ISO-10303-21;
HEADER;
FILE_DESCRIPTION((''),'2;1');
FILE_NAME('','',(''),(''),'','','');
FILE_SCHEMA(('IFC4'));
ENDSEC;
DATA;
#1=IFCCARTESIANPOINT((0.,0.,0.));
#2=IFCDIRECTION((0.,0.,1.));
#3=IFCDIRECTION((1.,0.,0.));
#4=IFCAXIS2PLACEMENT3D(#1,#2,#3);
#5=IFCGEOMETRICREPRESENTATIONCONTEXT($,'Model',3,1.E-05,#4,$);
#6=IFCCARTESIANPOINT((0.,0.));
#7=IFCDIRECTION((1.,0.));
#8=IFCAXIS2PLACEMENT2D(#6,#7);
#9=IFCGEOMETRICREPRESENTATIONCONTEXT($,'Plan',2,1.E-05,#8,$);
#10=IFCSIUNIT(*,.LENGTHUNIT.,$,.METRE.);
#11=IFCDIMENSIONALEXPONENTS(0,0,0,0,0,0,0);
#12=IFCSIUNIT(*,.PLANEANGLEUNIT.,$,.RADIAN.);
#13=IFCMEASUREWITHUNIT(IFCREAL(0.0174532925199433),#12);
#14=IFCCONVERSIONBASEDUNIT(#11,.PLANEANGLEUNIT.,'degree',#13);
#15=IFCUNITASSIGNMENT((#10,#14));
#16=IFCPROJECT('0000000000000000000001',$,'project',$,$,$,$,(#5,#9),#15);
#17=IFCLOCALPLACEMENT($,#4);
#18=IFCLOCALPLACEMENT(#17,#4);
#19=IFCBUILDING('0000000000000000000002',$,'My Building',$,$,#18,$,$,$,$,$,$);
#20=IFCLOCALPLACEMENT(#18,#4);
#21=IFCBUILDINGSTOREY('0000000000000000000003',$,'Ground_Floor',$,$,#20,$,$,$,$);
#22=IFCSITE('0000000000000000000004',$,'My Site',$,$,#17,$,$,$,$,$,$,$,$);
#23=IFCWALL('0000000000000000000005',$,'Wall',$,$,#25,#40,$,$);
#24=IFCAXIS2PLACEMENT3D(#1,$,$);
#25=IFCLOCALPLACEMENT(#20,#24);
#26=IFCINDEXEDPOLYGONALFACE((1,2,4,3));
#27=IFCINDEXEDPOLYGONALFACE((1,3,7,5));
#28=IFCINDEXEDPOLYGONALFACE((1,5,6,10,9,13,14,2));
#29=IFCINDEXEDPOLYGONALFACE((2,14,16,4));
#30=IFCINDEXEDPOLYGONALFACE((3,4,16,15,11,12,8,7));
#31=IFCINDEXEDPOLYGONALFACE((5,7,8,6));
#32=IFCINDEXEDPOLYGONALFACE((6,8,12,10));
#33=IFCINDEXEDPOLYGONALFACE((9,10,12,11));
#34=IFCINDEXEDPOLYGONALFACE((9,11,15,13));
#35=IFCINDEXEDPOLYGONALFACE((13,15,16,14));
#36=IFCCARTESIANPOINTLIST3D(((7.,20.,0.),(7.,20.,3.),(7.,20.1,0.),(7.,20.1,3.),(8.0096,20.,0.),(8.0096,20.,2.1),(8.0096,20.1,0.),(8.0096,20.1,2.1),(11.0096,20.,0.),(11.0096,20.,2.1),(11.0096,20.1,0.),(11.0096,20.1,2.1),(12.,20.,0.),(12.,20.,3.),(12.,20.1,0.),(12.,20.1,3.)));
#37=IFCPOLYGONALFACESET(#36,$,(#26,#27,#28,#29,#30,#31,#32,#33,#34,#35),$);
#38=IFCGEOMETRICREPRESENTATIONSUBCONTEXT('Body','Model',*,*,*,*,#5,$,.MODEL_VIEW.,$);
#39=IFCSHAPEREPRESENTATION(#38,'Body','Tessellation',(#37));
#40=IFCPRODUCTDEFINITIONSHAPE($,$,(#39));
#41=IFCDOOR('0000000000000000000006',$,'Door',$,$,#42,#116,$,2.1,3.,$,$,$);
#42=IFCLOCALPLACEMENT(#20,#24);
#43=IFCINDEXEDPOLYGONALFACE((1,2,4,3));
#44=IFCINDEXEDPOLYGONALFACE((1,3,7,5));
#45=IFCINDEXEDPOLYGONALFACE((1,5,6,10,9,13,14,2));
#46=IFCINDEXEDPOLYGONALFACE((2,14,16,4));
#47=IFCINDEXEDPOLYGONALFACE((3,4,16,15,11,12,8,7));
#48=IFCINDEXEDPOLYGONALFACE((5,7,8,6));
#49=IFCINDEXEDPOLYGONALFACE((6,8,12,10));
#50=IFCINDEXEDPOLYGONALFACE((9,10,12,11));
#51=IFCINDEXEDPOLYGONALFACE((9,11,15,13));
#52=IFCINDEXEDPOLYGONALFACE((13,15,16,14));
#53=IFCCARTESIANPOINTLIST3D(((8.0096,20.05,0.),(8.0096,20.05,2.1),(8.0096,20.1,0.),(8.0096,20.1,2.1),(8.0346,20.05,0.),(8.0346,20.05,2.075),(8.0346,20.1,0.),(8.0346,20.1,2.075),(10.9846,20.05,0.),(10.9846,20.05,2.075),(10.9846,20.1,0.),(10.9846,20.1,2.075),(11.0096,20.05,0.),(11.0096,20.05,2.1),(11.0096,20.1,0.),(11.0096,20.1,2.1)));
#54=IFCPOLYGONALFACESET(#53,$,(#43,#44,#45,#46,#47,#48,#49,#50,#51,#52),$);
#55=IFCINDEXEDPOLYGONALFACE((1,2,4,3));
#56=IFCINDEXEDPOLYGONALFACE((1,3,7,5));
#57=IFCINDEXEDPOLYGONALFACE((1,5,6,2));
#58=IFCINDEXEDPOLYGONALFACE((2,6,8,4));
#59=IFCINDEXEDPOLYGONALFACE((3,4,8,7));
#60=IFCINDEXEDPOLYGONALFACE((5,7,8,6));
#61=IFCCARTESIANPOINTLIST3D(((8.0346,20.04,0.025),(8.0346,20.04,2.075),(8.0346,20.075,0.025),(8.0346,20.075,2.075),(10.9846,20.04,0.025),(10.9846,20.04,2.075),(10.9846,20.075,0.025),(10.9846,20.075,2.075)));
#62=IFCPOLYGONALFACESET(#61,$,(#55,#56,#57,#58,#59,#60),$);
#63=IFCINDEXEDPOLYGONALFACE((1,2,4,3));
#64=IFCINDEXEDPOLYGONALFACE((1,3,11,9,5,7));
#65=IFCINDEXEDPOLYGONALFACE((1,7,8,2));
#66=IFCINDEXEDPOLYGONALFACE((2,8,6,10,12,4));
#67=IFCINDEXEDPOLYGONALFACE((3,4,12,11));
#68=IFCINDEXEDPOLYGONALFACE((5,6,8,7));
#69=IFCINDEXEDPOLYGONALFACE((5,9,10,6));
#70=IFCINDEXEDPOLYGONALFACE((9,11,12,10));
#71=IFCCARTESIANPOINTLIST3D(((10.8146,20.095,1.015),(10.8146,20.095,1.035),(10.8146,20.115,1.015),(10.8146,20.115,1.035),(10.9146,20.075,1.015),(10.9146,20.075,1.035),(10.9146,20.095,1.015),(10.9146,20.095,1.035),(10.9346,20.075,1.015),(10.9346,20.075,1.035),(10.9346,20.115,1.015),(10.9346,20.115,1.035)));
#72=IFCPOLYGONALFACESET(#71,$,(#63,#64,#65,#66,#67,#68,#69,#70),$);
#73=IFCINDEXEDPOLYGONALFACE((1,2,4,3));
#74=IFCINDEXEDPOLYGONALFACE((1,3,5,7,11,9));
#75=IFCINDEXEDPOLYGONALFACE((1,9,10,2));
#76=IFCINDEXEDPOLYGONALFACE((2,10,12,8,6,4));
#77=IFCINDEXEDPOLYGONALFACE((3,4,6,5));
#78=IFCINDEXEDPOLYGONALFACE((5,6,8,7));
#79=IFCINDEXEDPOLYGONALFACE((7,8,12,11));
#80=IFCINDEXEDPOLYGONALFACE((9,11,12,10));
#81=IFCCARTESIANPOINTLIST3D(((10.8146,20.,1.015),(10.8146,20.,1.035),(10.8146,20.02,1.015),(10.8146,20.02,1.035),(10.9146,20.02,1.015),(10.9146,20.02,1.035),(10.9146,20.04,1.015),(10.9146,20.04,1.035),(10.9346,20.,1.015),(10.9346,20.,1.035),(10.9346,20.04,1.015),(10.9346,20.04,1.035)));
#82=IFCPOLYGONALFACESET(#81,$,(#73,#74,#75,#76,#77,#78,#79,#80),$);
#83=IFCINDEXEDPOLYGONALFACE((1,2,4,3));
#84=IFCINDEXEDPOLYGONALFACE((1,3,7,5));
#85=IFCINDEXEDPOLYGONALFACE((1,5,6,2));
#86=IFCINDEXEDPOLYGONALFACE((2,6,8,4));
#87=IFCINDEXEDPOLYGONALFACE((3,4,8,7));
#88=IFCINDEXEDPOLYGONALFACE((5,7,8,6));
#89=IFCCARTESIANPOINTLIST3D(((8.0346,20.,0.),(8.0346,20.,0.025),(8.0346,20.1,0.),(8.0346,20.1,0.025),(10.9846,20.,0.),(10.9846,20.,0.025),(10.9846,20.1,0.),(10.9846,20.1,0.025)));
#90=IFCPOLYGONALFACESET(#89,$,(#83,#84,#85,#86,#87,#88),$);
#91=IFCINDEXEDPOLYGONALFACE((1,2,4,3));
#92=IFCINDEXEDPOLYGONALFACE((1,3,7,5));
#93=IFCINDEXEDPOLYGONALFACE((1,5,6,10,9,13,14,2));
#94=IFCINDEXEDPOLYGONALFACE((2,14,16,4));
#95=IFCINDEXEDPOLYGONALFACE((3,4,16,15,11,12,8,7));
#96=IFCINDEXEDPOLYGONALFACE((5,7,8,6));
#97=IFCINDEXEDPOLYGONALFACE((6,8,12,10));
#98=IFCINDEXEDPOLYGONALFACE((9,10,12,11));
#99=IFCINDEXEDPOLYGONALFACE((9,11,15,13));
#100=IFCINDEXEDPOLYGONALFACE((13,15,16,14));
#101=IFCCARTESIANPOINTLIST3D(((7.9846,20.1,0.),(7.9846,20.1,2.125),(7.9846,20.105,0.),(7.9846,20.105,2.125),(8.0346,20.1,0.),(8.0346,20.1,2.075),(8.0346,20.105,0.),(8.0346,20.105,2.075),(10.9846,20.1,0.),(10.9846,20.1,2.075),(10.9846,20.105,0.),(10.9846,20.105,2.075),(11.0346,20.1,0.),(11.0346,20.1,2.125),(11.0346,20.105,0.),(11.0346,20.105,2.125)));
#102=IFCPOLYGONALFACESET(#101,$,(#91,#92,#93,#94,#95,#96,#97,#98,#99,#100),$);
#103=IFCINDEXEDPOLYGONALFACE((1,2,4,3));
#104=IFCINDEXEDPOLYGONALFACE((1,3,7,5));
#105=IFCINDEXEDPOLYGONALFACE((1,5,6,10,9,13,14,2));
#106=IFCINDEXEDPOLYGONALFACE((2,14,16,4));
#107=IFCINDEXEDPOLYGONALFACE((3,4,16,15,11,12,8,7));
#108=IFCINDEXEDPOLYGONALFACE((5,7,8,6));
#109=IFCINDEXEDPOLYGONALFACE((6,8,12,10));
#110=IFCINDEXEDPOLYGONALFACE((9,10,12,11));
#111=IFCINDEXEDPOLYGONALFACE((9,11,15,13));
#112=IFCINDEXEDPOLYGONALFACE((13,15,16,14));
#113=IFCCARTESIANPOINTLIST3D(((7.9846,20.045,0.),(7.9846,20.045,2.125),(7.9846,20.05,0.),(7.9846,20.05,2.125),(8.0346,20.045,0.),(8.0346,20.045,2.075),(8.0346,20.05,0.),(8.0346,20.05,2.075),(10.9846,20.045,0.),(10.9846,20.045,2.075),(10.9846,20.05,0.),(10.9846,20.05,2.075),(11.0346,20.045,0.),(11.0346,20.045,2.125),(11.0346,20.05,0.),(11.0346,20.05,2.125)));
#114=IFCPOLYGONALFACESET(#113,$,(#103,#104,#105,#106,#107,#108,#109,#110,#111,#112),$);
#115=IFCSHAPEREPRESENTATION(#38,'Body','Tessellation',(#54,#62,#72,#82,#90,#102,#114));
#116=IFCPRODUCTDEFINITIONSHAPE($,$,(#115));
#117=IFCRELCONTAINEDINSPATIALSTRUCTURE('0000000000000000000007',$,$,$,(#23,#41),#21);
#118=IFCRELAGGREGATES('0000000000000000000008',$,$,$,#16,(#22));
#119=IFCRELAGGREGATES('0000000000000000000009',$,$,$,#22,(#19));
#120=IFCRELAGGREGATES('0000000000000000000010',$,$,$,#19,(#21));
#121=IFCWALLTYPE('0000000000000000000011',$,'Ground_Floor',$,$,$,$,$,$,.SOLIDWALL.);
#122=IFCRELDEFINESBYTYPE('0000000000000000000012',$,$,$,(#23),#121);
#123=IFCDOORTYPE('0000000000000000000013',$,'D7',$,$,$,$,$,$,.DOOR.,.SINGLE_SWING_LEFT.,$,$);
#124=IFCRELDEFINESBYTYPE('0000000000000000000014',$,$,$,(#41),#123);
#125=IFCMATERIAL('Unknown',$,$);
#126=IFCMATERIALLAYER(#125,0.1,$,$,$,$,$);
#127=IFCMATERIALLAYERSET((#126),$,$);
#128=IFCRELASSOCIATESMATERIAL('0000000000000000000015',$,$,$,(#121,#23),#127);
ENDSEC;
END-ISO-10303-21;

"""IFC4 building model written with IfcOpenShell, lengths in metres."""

from ifc_helpers import new_model, entity, si_unit, converted_unit, frame, origin_with_axes, origin_2d_with_axis, place, context, subcontext, project, spatial, line, indexed_curve, outline, extrude, shape, source, transform, mapped, material, layer, layer_set, layer_usage, type_object, type_shapes, element, fill, save


model = new_model("IFC4")

# Units and contexts
model_context = context("Model", 3, precision=1e-05, world=origin_with_axes())
plan_context = context("Plan", 2, precision=1e-05, world=origin_2d_with_axis())
body_context_1 = subcontext(model_context, "Body", "Model", "MODEL_VIEW")
body_context_2 = subcontext(plan_context, "Body", "Plan", "PLAN_VIEW")
ifc_project = project(units=[si_unit("LENGTHUNIT", "METRE"), converted_unit("PLANEANGLEUNIT", "degree", entity("IfcReal", 0.0174532925199433), si_unit("PLANEANGLEUNIT", "RADIAN"), dimensions=[0, 0, 0, 0, 0, 0, 0])], contexts=[model_context, plan_context])

# Site, building, storey
site_placement = place(None, origin_with_axes())
site = spatial("IfcSite", under=ifc_project, at=site_placement, Name="My Site")
building_placement = place(site_placement, origin_with_axes())
building = spatial("IfcBuilding", under=site, at=building_placement, Name="My Building")
storey_placement = place(building_placement, origin_with_axes())
storey = spatial("IfcBuildingStorey", under=building, at=storey_placement, Name="Ground_Floor")

# Shared definitions
ifc_material = material(Name="Unknown")

# Shared definitions
ifc_layer_1 = layer(ifc_material, 0.1)
ifc_layer_set_1 = layer_set([ifc_layer_1])
wall_type = type_object("IfcWallType", Name="Ground_Floor", PredefinedType="SOLIDWALL", material=ifc_layer_set_1)

# Wall, opening, door
ifc_layer_usage_1 = layer_usage(ifc_layer_set_1, "AXIS2", "POSITIVE", 0.0)
wall_1_placement = place(storey_placement, frame((7.0, 20.0, 0.0), z_axis=(0.0, 0.0, 1.0), x_axis=(1.0, 0.0, 0.0)))
wall_1 = element("IfcWall", 1, at=wall_1_placement, inside=storey, type_object=wall_type, material=ifc_layer_usage_1, Name="Wall", context=body_context_1, shape_type="SweptSolid", body=[
    extrude(outline(indexed_curve([(0.0, 0.0), (0.0, 0.1), (5.0, 0.1), (5.0, 0.0)], segments=[line(1, 2, 3, 4, 1)])), origin_with_axes(), (0.0, 0.0, 1.0), 3.0),
])
shared_shape_1 = source(origin_with_axes(), body_context_1, "Body", "SweptSolid", [
    extrude(outline(indexed_curve([(0.0, 0.0), (3.0, 0.0), (3.0, 2.1), (0.0, 2.1)], segments=[line(1, 2, 3, 4, 1)])), frame((0.0, -0.6, 0.0), z_axis=(0.0, -1.0, 0.0), x_axis=(1.0, 0.0, 0.0)), (0.0, 0.0, -1.0), 1.2),
])
opening_1_placement = place(wall_1_placement, frame((4.0096, 0.1, 0.0), z_axis=(0.0, 0.0, 1.0), x_axis=(-1.0, 0.0, 0.0)))
opening_1 = element("IfcOpeningElement", 2, at=opening_1_placement, cuts=wall_1, PredefinedType="OPENING", context=body_context_1, shape_type="MappedRepresentation", body=[
    mapped(shared_shape_1, transform((0.0, 0.0, 0.0), x_axis=(1.0, 0.0, 0.0), y_axis=(0.0, 1.0, 0.0), z_axis=(0.0, 0.0, 1.0), scale=1.0)),
])
door_type_1 = type_object("IfcDoorType", Name="D7", OperationType="SINGLE_SWING_LEFT", PredefinedType="DOOR")
shared_shape_2 = source(origin_with_axes(), body_context_1, "Body", "SweptSolid", [
    extrude(outline(indexed_curve([(0.0, 0.0), (0.0, 2.1), (3.0, 2.1), (3.0, 0.0), (2.975, 0.0), (2.975, 2.075), (0.025, 2.075), (0.025, 0.0)], segments=[line(1, 2, 3, 4, 5, 6, 7, 8, 1)])), frame((0.0, 0.0, 0.0), z_axis=(0.0, -1.0, 0.0), x_axis=(1.0, 0.0, 0.0)), (0.0, 0.0, -1.0), 0.05),
    extrude(outline(indexed_curve([(0.0, 0.0), (2.95, 0.0), (2.95, 0.035), (0.0, 0.035)], segments=[line(1, 2, 3, 4, 1)])), frame((0.025, 0.025, 0.025), z_axis=(0.0, 0.0, 1.0), x_axis=(1.0, 0.0, 0.0)), (0.0, 0.0, 1.0), 2.05),
    extrude(outline(indexed_curve([(0.0, 0.0), (0.0, -0.04), (0.12, -0.04), (0.12, -0.02), (0.02, -0.02), (0.02, 0.0)], segments=[line(1, 2, 3, 4, 5, 6, 1)])), frame((0.075, 0.025, 1.015), z_axis=(0.0, 0.0, 1.0), x_axis=(1.0, 0.0, 0.0)), (0.0, 0.0, 1.0), 0.02),
    extrude(outline(indexed_curve([(0.0, 0.0), (0.0, 0.04), (0.12, 0.04), (0.12, 0.02), (0.02, 0.02), (0.02, 0.0)], segments=[line(1, 2, 3, 4, 5, 6, 1)])), frame((0.075, 0.06, 1.015), z_axis=(0.0, 0.0, 1.0), x_axis=(1.0, 0.0, 0.0)), (0.0, 0.0, 1.0), 0.02),
    extrude(outline(indexed_curve([(0.0, 0.0), (2.95, 0.0), (2.95, 0.1), (0.0, 0.1)], segments=[line(1, 2, 3, 4, 1)])), frame((0.025, 0.0, 0.0), z_axis=(0.0, 0.0, 1.0), x_axis=(1.0, 0.0, 0.0)), (0.0, 0.0, 1.0), 0.025),
    extrude(outline(indexed_curve([(0.0, 0.0), (0.0, 2.125), (3.05, 2.125), (3.05, 0.0), (3.0, 0.0), (3.0, 2.075), (0.05, 2.075), (0.05, 0.0)], segments=[line(1, 2, 3, 4, 5, 6, 7, 8, 1)])), frame((-0.025, -0.005, 0.0), z_axis=(0.0, -1.0, 0.0), x_axis=(1.0, 0.0, 0.0)), (0.0, 0.0, -1.0), 0.005),
    extrude(outline(indexed_curve([(0.0, 0.0), (0.0, 2.125), (3.05, 2.125), (3.05, 0.0), (3.0, 0.0), (3.0, 2.075), (0.05, 2.075), (0.05, 0.0)], segments=[line(1, 2, 3, 4, 5, 6, 7, 8, 1)])), frame((-0.025, 0.05, 0.0), z_axis=(0.0, -1.0, 0.0), x_axis=(1.0, 0.0, 0.0)), (0.0, 0.0, -1.0), 0.005),
])
shared_shape_3 = source(origin_with_axes(), body_context_2, "Body", "Curve2D", [
    entity("IfcIndexedPolyCurve", entity("IfcCartesianPointList2D", [[0.0, 0.0], [0.025, 0.0], [0.025, 0.05], [0.0, 0.05]]), [entity("IfcLineIndex", [1, 2, 3, 4, 1])]),
    entity("IfcIndexedPolyCurve", entity("IfcCartesianPointList2D", [[3.0, 0.0], [2.975, 0.0], [2.975, 0.05], [3.0, 0.05]]), [entity("IfcLineIndex", [1, 2, 3, 4, 1])]),
    entity("IfcIndexedPolyCurve", entity("IfcCartesianPointList2D", [[2.975, 0.05], [2.975, -2.9], [2.94, -2.9]])),
    entity("IfcTrimmedCurve", entity("IfcEllipse", entity("IfcAxis2Placement2D", entity("IfcCartesianPoint", [2.94, 0.05]), entity("IfcDirection", [1.0, 0.0])), 2.915, 2.95), [entity("IfcCartesianPoint", [2.94, 3.0])], [entity("IfcCartesianPoint", [2.94, -2.9])], True, "CARTESIAN"),
    entity("IfcIndexedPolyCurve", entity("IfcCartesianPointList2D", [[2.975, 0.05], [2.94, 0.05], [2.94, 3.0], [2.975, 3.0]]), [entity("IfcLineIndex", [1, 2, 3, 4, 1])]),
])
type_shapes(door_type_1, [shared_shape_2, shared_shape_3])
door_1_placement = place(opening_1_placement, frame((0.0, 0.0, 0.0), z_axis=(0.0, 0.0, 1.0), x_axis=(1.0, 0.0, 0.0)))
door_1 = element("IfcDoor", 3, at=door_1_placement, inside=storey, type_object=door_type_1, Name="Door", OverallHeight=2.1, OverallWidth=3.0, shapes=[
    shape(body_context_1, "Body", "MappedRepresentation", [mapped(shared_shape_2, transform((0.0, 0.0, 0.0), x_axis=(1.0, 0.0, 0.0), y_axis=(0.0, 1.0, 0.0), z_axis=(0.0, 0.0, 1.0), scale=1.0))]),
    shape(body_context_2, "Body", "MappedRepresentation", [mapped(shared_shape_3, transform((0.0, 0.0, 0.0), x_axis=(1.0, 0.0, 0.0), y_axis=(0.0, 1.0, 0.0), z_axis=(0.0, 0.0, 1.0), scale=1.0))]),
])
fill(opening_1, door_1)

save(model, "model.ifc")
